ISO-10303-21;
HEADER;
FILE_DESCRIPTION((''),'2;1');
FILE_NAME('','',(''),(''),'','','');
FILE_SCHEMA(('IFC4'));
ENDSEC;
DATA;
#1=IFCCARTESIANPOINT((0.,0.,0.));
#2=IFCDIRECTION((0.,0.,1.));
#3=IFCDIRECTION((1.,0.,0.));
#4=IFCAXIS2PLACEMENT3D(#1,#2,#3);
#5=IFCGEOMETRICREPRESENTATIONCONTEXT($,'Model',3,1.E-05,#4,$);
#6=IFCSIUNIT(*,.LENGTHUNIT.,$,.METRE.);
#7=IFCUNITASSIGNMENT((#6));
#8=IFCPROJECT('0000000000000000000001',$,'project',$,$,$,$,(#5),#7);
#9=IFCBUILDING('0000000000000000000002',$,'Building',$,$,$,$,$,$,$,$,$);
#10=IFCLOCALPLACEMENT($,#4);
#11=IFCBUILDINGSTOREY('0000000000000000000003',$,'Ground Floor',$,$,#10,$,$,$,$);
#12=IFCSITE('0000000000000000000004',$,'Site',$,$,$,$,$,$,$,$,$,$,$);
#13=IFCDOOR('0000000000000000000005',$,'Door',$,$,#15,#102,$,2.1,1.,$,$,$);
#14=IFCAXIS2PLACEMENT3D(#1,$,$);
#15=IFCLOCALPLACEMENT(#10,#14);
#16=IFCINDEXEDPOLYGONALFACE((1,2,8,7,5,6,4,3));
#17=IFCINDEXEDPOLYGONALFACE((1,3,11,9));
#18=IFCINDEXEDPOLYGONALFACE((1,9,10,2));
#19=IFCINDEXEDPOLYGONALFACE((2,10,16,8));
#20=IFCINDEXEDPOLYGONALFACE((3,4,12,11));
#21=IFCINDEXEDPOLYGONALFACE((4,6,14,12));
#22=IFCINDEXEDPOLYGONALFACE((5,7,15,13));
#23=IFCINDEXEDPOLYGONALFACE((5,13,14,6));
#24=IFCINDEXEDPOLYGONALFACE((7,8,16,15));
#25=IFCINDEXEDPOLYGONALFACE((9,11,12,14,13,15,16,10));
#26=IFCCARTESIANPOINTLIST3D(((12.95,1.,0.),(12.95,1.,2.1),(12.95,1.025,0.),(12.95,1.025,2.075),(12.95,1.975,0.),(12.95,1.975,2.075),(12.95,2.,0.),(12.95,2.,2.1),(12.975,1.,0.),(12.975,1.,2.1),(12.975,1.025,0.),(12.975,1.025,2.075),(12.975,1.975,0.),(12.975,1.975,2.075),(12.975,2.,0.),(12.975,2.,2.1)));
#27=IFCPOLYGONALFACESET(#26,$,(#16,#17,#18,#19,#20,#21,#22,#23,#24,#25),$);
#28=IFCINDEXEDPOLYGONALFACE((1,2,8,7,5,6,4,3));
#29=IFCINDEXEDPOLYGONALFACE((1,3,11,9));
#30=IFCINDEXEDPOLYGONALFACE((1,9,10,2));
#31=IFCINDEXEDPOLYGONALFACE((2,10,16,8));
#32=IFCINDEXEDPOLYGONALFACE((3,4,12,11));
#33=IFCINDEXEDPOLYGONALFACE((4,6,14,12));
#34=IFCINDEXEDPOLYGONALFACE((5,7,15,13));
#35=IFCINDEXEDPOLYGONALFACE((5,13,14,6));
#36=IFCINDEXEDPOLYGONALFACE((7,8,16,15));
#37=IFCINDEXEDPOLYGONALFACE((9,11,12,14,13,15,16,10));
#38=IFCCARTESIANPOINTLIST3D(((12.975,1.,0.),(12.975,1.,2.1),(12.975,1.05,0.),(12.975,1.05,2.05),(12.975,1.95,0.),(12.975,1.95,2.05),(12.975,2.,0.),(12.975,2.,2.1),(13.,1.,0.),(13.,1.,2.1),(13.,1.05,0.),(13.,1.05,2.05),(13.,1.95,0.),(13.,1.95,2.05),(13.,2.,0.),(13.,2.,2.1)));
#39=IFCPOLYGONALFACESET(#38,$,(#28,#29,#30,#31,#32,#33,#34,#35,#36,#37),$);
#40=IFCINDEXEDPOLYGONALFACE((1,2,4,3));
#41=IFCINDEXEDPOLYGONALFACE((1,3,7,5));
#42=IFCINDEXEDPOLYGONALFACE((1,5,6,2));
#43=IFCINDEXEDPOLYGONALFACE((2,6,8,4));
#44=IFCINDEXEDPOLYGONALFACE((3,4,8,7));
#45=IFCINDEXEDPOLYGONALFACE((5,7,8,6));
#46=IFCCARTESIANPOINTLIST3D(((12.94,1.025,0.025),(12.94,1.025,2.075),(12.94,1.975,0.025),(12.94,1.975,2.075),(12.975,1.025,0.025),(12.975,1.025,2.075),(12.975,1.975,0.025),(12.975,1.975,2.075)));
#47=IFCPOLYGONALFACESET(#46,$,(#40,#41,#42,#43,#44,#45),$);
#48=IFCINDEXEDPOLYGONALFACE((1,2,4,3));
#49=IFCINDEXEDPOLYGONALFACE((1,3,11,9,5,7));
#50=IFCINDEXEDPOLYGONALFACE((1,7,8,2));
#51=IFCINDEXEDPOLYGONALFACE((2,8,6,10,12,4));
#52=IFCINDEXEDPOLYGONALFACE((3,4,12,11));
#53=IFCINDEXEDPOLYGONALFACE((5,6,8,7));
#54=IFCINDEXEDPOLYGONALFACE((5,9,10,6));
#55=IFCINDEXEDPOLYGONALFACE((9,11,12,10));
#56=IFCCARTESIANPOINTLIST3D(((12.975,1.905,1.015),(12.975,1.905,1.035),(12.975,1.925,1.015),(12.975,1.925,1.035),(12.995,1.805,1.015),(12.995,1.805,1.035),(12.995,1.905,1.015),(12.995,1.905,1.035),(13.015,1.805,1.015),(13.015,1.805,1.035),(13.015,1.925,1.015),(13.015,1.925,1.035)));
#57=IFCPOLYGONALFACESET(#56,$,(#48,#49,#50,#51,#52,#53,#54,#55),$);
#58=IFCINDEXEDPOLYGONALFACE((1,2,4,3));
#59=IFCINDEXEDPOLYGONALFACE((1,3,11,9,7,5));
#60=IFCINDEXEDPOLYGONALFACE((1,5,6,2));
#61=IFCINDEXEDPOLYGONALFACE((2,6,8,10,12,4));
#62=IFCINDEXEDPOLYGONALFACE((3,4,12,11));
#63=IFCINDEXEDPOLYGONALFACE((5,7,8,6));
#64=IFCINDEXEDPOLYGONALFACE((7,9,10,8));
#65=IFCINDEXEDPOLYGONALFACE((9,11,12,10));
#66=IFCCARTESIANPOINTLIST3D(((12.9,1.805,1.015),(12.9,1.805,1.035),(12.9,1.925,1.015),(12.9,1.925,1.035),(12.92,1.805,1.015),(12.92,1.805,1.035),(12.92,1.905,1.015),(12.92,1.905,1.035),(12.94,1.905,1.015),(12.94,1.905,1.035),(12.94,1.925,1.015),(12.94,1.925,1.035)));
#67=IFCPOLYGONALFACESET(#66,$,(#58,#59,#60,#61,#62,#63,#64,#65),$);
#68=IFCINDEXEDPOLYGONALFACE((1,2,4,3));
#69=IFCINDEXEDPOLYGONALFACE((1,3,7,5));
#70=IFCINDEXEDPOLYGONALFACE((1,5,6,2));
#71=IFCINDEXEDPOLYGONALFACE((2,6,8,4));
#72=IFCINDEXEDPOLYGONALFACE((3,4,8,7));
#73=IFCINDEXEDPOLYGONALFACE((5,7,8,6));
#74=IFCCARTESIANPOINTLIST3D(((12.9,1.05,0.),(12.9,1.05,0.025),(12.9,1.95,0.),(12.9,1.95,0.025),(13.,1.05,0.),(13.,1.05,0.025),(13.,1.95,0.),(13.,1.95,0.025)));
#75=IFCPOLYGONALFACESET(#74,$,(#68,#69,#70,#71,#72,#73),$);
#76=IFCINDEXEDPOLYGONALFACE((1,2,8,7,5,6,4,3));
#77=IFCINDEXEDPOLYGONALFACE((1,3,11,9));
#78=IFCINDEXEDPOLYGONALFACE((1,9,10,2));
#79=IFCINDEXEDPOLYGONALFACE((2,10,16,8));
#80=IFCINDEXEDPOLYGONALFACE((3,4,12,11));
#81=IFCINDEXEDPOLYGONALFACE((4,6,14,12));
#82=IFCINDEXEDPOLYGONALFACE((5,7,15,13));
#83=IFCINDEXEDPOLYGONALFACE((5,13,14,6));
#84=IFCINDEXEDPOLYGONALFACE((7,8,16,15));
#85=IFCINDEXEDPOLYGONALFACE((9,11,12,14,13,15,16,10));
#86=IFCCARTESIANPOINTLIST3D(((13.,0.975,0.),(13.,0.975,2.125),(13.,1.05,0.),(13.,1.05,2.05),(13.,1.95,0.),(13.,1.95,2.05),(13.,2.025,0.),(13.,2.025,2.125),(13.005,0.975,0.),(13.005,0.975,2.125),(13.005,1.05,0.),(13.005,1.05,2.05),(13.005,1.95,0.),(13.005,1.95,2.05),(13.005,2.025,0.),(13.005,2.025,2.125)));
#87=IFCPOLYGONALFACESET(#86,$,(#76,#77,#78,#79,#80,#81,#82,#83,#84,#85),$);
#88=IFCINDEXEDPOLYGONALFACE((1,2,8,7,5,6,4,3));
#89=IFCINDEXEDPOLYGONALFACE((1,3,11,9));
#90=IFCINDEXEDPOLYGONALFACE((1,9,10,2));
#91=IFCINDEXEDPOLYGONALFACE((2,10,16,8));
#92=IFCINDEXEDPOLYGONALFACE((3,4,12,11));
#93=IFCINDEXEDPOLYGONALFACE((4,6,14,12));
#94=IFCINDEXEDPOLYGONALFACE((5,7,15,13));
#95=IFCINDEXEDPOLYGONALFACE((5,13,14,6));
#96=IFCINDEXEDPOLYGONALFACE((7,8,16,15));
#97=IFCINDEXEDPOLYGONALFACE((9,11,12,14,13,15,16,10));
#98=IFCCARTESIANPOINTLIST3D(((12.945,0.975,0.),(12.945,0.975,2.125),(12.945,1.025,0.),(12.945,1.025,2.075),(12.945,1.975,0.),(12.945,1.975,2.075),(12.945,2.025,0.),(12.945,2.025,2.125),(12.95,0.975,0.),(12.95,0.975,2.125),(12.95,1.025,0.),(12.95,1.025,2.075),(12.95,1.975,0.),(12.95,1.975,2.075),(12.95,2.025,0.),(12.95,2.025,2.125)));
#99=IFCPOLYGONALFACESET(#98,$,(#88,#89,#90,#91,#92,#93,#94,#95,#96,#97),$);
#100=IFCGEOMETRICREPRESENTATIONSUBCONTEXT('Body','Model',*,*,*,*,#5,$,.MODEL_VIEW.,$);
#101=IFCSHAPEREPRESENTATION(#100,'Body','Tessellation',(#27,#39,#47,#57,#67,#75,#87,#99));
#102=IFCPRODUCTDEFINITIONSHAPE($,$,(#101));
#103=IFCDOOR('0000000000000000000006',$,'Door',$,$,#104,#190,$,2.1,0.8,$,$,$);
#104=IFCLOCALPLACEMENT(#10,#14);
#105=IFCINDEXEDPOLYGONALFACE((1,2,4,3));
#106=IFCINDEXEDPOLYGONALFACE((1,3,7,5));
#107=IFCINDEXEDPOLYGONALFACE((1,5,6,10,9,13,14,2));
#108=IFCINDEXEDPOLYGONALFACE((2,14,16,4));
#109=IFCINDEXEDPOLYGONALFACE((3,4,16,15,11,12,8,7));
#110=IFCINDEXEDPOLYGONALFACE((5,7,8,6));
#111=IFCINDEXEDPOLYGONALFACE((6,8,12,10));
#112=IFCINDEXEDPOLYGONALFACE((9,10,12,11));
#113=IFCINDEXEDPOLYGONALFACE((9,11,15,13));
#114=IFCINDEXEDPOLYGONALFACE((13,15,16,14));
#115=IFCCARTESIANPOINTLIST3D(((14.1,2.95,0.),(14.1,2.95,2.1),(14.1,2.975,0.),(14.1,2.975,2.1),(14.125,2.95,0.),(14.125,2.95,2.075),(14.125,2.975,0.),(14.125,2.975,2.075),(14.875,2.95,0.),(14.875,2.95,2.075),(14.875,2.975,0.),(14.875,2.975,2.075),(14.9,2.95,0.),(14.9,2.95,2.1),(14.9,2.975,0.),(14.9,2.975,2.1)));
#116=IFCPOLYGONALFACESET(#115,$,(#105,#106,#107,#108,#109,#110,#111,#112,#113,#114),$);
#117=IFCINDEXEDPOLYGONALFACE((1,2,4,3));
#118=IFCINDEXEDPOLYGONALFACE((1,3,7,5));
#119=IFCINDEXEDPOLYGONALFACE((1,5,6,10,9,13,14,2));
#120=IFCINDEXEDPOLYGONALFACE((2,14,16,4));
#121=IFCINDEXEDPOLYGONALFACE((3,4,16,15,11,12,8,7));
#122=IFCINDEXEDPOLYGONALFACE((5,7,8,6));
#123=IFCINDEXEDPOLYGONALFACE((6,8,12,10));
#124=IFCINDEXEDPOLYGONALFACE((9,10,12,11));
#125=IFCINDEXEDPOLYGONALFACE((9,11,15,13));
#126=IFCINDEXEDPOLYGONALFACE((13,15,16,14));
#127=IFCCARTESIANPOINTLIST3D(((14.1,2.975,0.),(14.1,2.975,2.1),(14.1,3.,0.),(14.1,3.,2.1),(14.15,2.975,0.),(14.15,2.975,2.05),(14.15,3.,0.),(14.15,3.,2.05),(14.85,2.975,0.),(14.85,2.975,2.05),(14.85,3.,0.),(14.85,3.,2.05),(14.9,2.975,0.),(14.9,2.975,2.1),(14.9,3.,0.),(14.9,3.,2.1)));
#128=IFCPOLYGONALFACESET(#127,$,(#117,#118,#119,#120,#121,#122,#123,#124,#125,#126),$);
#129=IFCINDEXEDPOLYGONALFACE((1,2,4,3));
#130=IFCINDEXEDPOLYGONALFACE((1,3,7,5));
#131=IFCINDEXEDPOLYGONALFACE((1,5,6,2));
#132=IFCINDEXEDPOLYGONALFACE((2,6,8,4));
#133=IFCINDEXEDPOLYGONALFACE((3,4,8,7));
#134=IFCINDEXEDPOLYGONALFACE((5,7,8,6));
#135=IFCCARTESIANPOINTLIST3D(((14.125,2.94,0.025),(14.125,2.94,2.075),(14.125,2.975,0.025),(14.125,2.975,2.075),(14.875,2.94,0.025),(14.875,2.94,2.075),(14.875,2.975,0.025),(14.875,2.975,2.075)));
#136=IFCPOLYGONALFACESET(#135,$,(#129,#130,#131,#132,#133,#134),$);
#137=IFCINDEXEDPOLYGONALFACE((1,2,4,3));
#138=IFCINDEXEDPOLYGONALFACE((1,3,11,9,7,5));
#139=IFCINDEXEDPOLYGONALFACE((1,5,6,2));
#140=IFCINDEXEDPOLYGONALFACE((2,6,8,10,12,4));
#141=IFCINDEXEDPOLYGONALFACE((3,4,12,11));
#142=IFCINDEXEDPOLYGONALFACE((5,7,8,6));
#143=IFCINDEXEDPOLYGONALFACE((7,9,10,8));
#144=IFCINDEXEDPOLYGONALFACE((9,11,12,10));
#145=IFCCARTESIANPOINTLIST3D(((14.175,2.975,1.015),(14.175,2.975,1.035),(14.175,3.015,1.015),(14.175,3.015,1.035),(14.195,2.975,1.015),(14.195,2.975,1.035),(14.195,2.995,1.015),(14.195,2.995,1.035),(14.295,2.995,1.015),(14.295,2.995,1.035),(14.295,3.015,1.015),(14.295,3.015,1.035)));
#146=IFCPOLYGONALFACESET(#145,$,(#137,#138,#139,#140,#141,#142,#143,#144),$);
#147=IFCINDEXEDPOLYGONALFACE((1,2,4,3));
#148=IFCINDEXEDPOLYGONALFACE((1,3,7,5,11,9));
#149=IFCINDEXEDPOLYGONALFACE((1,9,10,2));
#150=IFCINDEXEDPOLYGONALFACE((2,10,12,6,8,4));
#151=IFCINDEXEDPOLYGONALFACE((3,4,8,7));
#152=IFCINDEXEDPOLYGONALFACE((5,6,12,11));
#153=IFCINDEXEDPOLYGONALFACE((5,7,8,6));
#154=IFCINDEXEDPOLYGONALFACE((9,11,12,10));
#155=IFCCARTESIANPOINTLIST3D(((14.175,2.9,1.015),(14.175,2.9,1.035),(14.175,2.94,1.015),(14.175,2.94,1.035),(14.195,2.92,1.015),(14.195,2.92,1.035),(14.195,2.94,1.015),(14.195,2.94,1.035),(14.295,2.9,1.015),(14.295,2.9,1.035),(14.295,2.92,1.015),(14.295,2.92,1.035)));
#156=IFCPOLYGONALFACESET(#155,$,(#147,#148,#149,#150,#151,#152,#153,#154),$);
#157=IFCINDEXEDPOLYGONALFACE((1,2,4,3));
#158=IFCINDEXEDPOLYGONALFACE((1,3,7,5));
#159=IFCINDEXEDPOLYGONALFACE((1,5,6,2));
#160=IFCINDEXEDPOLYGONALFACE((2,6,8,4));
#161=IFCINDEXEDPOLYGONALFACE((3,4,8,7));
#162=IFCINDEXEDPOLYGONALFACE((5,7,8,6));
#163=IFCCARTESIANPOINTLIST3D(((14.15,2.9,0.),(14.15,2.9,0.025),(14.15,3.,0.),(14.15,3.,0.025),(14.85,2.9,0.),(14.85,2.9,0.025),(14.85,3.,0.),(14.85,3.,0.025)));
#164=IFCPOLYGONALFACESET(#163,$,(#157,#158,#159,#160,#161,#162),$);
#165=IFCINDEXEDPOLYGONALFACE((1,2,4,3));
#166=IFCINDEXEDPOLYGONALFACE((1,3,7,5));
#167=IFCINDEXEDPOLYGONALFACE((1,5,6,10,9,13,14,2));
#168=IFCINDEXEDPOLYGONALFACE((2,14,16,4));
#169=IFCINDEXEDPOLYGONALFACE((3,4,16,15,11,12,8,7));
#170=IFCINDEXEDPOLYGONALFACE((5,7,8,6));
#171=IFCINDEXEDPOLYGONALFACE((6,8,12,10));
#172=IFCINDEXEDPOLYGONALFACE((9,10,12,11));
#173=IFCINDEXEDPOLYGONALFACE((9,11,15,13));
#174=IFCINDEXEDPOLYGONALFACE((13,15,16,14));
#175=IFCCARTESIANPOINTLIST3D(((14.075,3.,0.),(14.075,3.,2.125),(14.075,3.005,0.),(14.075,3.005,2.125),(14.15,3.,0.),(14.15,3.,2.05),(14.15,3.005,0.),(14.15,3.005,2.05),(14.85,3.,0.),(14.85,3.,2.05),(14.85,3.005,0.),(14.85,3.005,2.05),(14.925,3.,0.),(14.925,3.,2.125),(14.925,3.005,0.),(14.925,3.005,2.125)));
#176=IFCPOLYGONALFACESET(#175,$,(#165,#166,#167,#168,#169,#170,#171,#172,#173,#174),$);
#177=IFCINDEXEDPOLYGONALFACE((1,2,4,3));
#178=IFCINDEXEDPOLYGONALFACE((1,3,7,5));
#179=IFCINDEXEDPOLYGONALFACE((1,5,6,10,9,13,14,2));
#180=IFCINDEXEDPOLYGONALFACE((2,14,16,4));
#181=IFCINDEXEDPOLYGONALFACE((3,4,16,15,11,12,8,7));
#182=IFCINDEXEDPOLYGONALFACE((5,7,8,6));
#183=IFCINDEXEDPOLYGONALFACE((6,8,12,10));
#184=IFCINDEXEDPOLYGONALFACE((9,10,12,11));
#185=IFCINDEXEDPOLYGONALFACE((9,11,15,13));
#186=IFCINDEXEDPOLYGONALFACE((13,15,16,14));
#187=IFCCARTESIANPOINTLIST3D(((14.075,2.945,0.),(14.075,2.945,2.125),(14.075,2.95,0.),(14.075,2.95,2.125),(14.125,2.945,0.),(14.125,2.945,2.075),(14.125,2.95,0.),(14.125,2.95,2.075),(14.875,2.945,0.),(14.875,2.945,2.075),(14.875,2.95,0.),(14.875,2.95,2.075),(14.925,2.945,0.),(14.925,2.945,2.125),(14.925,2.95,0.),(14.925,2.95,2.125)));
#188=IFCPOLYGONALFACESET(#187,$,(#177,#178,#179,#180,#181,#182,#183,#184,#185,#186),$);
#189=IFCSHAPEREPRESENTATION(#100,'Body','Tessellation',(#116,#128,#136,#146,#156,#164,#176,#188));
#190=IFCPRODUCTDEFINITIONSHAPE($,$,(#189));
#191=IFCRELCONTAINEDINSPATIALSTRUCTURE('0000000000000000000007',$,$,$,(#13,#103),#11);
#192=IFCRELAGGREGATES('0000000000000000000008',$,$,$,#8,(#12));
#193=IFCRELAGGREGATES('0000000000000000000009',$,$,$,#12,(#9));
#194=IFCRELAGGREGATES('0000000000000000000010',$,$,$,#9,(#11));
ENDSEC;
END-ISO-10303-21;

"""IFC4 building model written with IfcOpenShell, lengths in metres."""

from ifc_helpers import new_model, si_unit, frame, origin_with_axes, place, context, subcontext, project, spatial, line, indexed_curve, outline, extrude, element, save


model = new_model("IFC4")

# Units and contexts
model_context = context("Model", 3, precision=1e-05, world=origin_with_axes())
body_context = subcontext(model_context, "Body", "Model", "MODEL_VIEW")
ifc_project = project(units=[si_unit("LENGTHUNIT", "METRE")], contexts=[model_context])

# Site, building, storey
site = spatial("IfcSite", under=ifc_project, Name="Site")
building = spatial("IfcBuilding", under=site, Name="Building")
storey_placement = place(None, origin_with_axes())
storey = spatial("IfcBuildingStorey", under=building, at=storey_placement, Name="Ground Floor")

# Doors
door_1_placement = place(storey_placement, frame((13.0, 1.0, 0.0), z_axis=(0.0, 0.0, 1.0), x_axis=(0.0, 1.0, 0.0)))
element("IfcDoor", 1, at=door_1_placement, inside=storey, Name="Door", OverallHeight=2.1, OverallWidth=1.0, context=body_context, shape_type="SweptSolid", body=[
    extrude(outline(indexed_curve([(0.0, 0.0), (0.0, 2.1), (1.0, 2.1), (1.0, 0.0), (0.975, 0.0), (0.975, 2.075), (0.025, 2.075), (0.025, 0.0)], segments=[line(1, 2, 3, 4, 5, 6, 7, 8, 1)])), frame((0.0, 0.025, 0.0), z_axis=(0.0, -1.0, 0.0), x_axis=(1.0, 0.0, 0.0)), (0.0, 0.0, -1.0), 0.025),
    extrude(outline(indexed_curve([(0.0, 0.0), (0.0, 2.1), (1.0, 2.1), (1.0, 0.0), (0.95, 0.0), (0.95, 2.05), (0.05, 2.05), (0.05, 0.0)], segments=[line(1, 2, 3, 4, 5, 6, 7, 8, 1)])), frame((0.0, 0.0, 0.0), z_axis=(0.0, -1.0, 0.0), x_axis=(1.0, 0.0, 0.0)), (0.0, 0.0, -1.0), 0.025),
    extrude(outline(indexed_curve([(0.0, 0.0), (0.95, 0.0), (0.95, 0.035), (0.0, 0.035)], segments=[line(1, 2, 3, 4, 1)])), frame((0.025, 0.025, 0.025), z_axis=(0.0, 0.0, 1.0), x_axis=(1.0, 0.0, 0.0)), (0.0, 0.0, 1.0), 2.05),
    extrude(outline(indexed_curve([(0.0, 0.0), (0.0, -0.04), (-0.12, -0.04), (-0.12, -0.02), (-0.02, -0.02), (-0.02, 0.0)], segments=[line(1, 2, 3, 4, 5, 6, 1)])), frame((0.925, 0.025, 1.015), z_axis=(0.0, 0.0, 1.0), x_axis=(1.0, 0.0, 0.0)), (0.0, 0.0, 1.0), 0.02),
    extrude(outline(indexed_curve([(0.0, 0.0), (0.0, 0.04), (-0.12, 0.04), (-0.12, 0.02), (-0.02, 0.02), (-0.02, 0.0)], segments=[line(1, 2, 3, 4, 5, 6, 1)])), frame((0.925, 0.06, 1.015), z_axis=(0.0, 0.0, 1.0), x_axis=(1.0, 0.0, 0.0)), (0.0, 0.0, 1.0), 0.02),
    extrude(outline(indexed_curve([(0.0, 0.0), (0.9, 0.0), (0.9, 0.1), (0.0, 0.1)], segments=[line(1, 2, 3, 4, 1)])), frame((0.05, 0.0, 0.0), z_axis=(0.0, 0.0, 1.0), x_axis=(1.0, 0.0, 0.0)), (0.0, 0.0, 1.0), 0.025),
    extrude(outline(indexed_curve([(0.0, 0.0), (0.0, 2.125), (1.05, 2.125), (1.05, 0.0), (0.975, 0.0), (0.975, 2.05), (0.075, 2.05), (0.075, 0.0)], segments=[line(1, 2, 3, 4, 5, 6, 7, 8, 1)])), frame((-0.025, -0.005, 0.0), z_axis=(0.0, -1.0, 0.0), x_axis=(1.0, 0.0, 0.0)), (0.0, 0.0, -1.0), 0.005),
    extrude(outline(indexed_curve([(0.0, 0.0), (0.0, 2.125), (1.05, 2.125), (1.05, 0.0), (1.0, 0.0), (1.0, 2.075), (0.05, 2.075), (0.05, 0.0)], segments=[line(1, 2, 3, 4, 5, 6, 7, 8, 1)])), frame((-0.025, 0.05, 0.0), z_axis=(0.0, -1.0, 0.0), x_axis=(1.0, 0.0, 0.0)), (0.0, 0.0, -1.0), 0.005),
])
door_2_placement = place(storey_placement, frame((14.9, 3.0, 0.0), z_axis=(0.0, 0.0, 1.0), x_axis=(-1.0, 0.0, 0.0)))
element("IfcDoor", 2, at=door_2_placement, inside=storey, Name="Door", OverallHeight=2.1, OverallWidth=0.8, context=body_context, shape_type="SweptSolid", body=[
    extrude(outline(indexed_curve([(0.0, 0.0), (0.0, 2.1), (0.8, 2.1), (0.8, 0.0), (0.775, 0.0), (0.775, 2.075), (0.025, 2.075), (0.025, 0.0)], segments=[line(1, 2, 3, 4, 5, 6, 7, 8, 1)])), frame((0.0, 0.025, 0.0), z_axis=(0.0, -1.0, 0.0), x_axis=(1.0, 0.0, 0.0)), (0.0, 0.0, -1.0), 0.025),
    extrude(outline(indexed_curve([(0.0, 0.0), (0.0, 2.1), (0.8, 2.1), (0.8, 0.0), (0.75, 0.0), (0.75, 2.05), (0.05, 2.05), (0.05, 0.0)], segments=[line(1, 2, 3, 4, 5, 6, 7, 8, 1)])), frame((0.0, 0.0, 0.0), z_axis=(0.0, -1.0, 0.0), x_axis=(1.0, 0.0, 0.0)), (0.0, 0.0, -1.0), 0.025),
    extrude(outline(indexed_curve([(0.0, 0.0), (0.75, 0.0), (0.75, 0.035), (0.0, 0.035)], segments=[line(1, 2, 3, 4, 1)])), frame((0.025, 0.025, 0.025), z_axis=(0.0, 0.0, 1.0), x_axis=(1.0, 0.0, 0.0)), (0.0, 0.0, 1.0), 2.05),
    extrude(outline(indexed_curve([(0.0, 0.0), (0.0, -0.04), (-0.12, -0.04), (-0.12, -0.02), (-0.02, -0.02), (-0.02, 0.0)], segments=[line(1, 2, 3, 4, 5, 6, 1)])), frame((0.725, 0.025, 1.015), z_axis=(0.0, 0.0, 1.0), x_axis=(1.0, 0.0, 0.0)), (0.0, 0.0, 1.0), 0.02),
    extrude(outline(indexed_curve([(0.0, 0.0), (0.0, 0.04), (-0.12, 0.04), (-0.12, 0.02), (-0.02, 0.02), (-0.02, 0.0)], segments=[line(1, 2, 3, 4, 5, 6, 1)])), frame((0.725, 0.06, 1.015), z_axis=(0.0, 0.0, 1.0), x_axis=(1.0, 0.0, 0.0)), (0.0, 0.0, 1.0), 0.02),
    extrude(outline(indexed_curve([(0.0, 0.0), (0.7, 0.0), (0.7, 0.1), (0.0, 0.1)], segments=[line(1, 2, 3, 4, 1)])), frame((0.05, 0.0, 0.0), z_axis=(0.0, 0.0, 1.0), x_axis=(1.0, 0.0, 0.0)), (0.0, 0.0, 1.0), 0.025),
    extrude(outline(indexed_curve([(0.0, 0.0), (0.0, 2.125), (0.85, 2.125), (0.85, 0.0), (0.775, 0.0), (0.775, 2.05), (0.075, 2.05), (0.075, 0.0)], segments=[line(1, 2, 3, 4, 5, 6, 7, 8, 1)])), frame((-0.025, -0.005, 0.0), z_axis=(0.0, -1.0, 0.0), x_axis=(1.0, 0.0, 0.0)), (0.0, 0.0, -1.0), 0.005),
    extrude(outline(indexed_curve([(0.0, 0.0), (0.0, 2.125), (0.85, 2.125), (0.85, 0.0), (0.8, 0.0), (0.8, 2.075), (0.05, 2.075), (0.05, 0.0)], segments=[line(1, 2, 3, 4, 5, 6, 7, 8, 1)])), frame((-0.025, 0.05, 0.0), z_axis=(0.0, -1.0, 0.0), x_axis=(1.0, 0.0, 0.0)), (0.0, 0.0, -1.0), 0.005),
])

save(model, "model.ifc")
